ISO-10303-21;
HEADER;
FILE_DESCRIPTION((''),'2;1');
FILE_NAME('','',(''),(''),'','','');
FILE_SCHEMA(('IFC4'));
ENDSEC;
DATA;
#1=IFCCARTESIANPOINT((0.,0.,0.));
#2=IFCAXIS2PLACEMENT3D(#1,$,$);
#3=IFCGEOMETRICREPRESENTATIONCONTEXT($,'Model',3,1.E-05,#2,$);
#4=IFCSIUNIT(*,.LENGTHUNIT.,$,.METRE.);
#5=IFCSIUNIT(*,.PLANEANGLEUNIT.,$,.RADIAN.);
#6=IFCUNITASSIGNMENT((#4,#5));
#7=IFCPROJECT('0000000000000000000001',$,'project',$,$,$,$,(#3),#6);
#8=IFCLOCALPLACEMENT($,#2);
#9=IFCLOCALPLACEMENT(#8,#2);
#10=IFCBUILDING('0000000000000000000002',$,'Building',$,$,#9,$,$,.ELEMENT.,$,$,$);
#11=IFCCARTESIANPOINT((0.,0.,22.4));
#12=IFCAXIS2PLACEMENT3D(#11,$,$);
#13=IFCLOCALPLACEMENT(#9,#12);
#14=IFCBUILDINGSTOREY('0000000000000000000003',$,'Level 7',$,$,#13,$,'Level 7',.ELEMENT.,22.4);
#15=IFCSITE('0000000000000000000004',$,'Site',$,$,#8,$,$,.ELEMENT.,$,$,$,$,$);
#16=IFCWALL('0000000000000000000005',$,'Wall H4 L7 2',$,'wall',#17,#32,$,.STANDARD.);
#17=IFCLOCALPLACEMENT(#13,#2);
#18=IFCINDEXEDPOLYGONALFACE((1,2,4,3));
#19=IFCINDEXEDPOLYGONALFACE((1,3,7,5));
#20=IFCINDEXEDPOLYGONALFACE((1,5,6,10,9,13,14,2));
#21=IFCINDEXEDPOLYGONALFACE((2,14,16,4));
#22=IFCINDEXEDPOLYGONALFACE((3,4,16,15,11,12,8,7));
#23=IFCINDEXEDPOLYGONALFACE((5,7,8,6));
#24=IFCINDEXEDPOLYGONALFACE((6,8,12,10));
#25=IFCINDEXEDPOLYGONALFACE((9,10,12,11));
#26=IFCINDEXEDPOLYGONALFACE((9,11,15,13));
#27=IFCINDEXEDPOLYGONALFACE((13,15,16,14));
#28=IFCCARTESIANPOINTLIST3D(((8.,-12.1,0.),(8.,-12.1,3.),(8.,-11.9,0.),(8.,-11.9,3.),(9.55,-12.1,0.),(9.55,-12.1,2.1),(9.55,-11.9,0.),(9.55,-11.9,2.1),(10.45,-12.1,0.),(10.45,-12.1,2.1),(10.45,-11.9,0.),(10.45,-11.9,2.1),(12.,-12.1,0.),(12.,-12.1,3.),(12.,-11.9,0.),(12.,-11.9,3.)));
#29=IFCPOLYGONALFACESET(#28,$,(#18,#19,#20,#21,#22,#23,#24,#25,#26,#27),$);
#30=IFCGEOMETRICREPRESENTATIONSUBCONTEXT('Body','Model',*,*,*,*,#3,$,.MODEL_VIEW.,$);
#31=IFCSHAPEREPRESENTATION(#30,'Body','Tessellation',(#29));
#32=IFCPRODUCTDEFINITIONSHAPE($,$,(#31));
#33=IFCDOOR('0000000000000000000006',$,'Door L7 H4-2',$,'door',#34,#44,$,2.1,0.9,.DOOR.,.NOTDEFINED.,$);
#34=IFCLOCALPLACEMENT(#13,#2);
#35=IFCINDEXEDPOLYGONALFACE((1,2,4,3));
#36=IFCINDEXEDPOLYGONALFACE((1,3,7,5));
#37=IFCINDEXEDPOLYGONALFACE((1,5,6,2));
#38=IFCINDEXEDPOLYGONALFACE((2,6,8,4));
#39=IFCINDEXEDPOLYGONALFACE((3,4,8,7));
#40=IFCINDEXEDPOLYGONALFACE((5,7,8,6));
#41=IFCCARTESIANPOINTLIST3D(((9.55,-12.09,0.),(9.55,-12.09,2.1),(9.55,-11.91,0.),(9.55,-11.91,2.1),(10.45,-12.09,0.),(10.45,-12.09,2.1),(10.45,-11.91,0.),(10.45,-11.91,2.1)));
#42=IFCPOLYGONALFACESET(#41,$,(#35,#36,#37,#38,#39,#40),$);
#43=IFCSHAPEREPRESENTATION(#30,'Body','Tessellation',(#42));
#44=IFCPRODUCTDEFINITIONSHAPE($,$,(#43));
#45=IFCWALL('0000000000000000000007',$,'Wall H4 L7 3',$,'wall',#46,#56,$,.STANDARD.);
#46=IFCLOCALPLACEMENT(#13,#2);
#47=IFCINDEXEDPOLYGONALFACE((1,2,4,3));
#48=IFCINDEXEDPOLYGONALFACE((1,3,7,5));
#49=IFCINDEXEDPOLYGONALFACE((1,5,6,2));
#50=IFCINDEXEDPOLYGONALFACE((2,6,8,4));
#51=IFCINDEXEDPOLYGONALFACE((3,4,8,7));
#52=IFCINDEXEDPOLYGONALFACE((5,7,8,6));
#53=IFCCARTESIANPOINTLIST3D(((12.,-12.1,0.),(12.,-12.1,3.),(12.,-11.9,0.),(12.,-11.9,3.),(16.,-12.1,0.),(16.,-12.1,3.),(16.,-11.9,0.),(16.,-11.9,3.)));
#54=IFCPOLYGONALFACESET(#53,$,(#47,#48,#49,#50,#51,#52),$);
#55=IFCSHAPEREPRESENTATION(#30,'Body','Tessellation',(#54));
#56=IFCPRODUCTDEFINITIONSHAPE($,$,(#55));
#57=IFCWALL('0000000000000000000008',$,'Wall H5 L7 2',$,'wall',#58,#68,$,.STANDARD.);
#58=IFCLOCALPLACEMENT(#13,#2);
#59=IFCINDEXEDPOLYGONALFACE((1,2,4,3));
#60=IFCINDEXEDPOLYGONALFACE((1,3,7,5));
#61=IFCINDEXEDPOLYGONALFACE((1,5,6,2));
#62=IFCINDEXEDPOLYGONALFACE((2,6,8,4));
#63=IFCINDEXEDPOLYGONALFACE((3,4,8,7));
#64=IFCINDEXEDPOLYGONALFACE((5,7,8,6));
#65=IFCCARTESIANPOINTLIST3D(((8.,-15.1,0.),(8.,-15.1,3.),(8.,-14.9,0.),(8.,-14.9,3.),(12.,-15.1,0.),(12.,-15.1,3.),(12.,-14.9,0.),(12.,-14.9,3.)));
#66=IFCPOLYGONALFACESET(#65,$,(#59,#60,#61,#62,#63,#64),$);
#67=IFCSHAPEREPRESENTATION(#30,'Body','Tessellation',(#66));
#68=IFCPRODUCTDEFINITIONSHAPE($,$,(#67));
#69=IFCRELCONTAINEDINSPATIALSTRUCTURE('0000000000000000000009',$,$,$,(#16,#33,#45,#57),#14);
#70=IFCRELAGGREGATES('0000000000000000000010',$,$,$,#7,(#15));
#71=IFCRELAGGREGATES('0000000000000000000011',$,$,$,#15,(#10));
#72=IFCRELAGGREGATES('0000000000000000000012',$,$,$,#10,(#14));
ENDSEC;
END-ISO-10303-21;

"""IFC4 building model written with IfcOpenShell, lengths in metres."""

from ifc_helpers import new_model, si_unit, frame, frame_2d, origin, origin_2d, place, context, subcontext, project, spatial, rectangle, extrude, element, fill, save


model = new_model("IFC4")

# Units and contexts
model_context = context("Model", 3, precision=1e-05, world=origin())
body_context = subcontext(model_context, "Body", "Model", "MODEL_VIEW")
ifc_project = project(units=[si_unit("LENGTHUNIT", "METRE"), si_unit("PLANEANGLEUNIT", "RADIAN")], contexts=[model_context])

# Site, building, storey
site_placement = place(None, origin())
site = spatial("IfcSite", under=ifc_project, at=site_placement, Name="Site", CompositionType="ELEMENT")
building_placement = place(site_placement, origin())
building = spatial("IfcBuilding", under=site, at=building_placement, Name="Building", CompositionType="ELEMENT")
storey_placement = place(building_placement, frame((0.0, 0.0, 22.4)))
storey = spatial("IfcBuildingStorey", under=building, at=storey_placement, Name="Level 7", LongName="Level 7", CompositionType="ELEMENT", Elevation=22.4)

# Wall, opening, door
wall_1_placement = place(storey_placement, frame((8.0, -12.0, 0.0), z_axis=(0.0, 0.0, 1.0), x_axis=(1.0, 0.0, 0.0)))
wall_1 = element("IfcWall", 1, at=wall_1_placement, inside=storey, Name="Wall H4 L7 2", ObjectType="wall", PredefinedType="STANDARD", context=body_context, shape_type="SweptSolid", body=[
    extrude(rectangle(XDim=4.0, YDim=0.2, at=frame_2d((2.0, 0.0))), origin(), (0.0, 0.0, 1.0), 3.0),
])
opening_1_placement = place(storey_placement, frame((10.0, -12.0, 0.0), z_axis=(0.0, 0.0, 1.0), x_axis=(1.0, 0.0, 0.0)))
opening_1 = element("IfcOpeningElement", 2, at=opening_1_placement, cuts=wall_1, ObjectType="Opening", PredefinedType="OPENING", context=body_context, shape_type="SweptSolid", body=[
    extrude(rectangle(XDim=0.9, YDim=0.22, at=origin_2d()), origin(), (0.0, 0.0, 1.0), 2.1),
])
door_1_placement = place(storey_placement, frame((10.0, -12.0, 0.0), z_axis=(0.0, 0.0, 1.0), x_axis=(1.0, 0.0, 0.0)))
door_1 = element("IfcDoor", 3, at=door_1_placement, inside=storey, Name="Door L7 H4-2", ObjectType="door", OperationType="NOTDEFINED", OverallHeight=2.1, OverallWidth=0.9, PredefinedType="DOOR", context=body_context, shape_type="SweptSolid", body=[
    extrude(rectangle(XDim=0.9, YDim=0.18, at=origin_2d()), origin(), (0.0, 0.0, 1.0), 2.1),
])
fill(opening_1, door_1)

# Walls
for number, where, z_axis, x_axis, name in (
    (4, (12.0, -12.0, 0.0), (0.0, 0.0, 1.0), (1.0, 0.0, 0.0), "Wall H4 L7 3"),
    (5, (8.0, -15.0, 0.0), (0.0, 0.0, 1.0), (1.0, 0.0, 0.0), "Wall H5 L7 2"),
):
    element("IfcWall", number, at=place(storey_placement, frame(where, z_axis=z_axis, x_axis=x_axis)), inside=storey, Name=name, ObjectType="wall", PredefinedType="STANDARD", context=body_context, shape_type="SweptSolid", body=[
        extrude(rectangle(XDim=4.0, YDim=0.2, at=frame_2d((2.0, 0.0))), origin(), (0.0, 0.0, 1.0), 3.0),
    ])

save(model, "model.ifc")
